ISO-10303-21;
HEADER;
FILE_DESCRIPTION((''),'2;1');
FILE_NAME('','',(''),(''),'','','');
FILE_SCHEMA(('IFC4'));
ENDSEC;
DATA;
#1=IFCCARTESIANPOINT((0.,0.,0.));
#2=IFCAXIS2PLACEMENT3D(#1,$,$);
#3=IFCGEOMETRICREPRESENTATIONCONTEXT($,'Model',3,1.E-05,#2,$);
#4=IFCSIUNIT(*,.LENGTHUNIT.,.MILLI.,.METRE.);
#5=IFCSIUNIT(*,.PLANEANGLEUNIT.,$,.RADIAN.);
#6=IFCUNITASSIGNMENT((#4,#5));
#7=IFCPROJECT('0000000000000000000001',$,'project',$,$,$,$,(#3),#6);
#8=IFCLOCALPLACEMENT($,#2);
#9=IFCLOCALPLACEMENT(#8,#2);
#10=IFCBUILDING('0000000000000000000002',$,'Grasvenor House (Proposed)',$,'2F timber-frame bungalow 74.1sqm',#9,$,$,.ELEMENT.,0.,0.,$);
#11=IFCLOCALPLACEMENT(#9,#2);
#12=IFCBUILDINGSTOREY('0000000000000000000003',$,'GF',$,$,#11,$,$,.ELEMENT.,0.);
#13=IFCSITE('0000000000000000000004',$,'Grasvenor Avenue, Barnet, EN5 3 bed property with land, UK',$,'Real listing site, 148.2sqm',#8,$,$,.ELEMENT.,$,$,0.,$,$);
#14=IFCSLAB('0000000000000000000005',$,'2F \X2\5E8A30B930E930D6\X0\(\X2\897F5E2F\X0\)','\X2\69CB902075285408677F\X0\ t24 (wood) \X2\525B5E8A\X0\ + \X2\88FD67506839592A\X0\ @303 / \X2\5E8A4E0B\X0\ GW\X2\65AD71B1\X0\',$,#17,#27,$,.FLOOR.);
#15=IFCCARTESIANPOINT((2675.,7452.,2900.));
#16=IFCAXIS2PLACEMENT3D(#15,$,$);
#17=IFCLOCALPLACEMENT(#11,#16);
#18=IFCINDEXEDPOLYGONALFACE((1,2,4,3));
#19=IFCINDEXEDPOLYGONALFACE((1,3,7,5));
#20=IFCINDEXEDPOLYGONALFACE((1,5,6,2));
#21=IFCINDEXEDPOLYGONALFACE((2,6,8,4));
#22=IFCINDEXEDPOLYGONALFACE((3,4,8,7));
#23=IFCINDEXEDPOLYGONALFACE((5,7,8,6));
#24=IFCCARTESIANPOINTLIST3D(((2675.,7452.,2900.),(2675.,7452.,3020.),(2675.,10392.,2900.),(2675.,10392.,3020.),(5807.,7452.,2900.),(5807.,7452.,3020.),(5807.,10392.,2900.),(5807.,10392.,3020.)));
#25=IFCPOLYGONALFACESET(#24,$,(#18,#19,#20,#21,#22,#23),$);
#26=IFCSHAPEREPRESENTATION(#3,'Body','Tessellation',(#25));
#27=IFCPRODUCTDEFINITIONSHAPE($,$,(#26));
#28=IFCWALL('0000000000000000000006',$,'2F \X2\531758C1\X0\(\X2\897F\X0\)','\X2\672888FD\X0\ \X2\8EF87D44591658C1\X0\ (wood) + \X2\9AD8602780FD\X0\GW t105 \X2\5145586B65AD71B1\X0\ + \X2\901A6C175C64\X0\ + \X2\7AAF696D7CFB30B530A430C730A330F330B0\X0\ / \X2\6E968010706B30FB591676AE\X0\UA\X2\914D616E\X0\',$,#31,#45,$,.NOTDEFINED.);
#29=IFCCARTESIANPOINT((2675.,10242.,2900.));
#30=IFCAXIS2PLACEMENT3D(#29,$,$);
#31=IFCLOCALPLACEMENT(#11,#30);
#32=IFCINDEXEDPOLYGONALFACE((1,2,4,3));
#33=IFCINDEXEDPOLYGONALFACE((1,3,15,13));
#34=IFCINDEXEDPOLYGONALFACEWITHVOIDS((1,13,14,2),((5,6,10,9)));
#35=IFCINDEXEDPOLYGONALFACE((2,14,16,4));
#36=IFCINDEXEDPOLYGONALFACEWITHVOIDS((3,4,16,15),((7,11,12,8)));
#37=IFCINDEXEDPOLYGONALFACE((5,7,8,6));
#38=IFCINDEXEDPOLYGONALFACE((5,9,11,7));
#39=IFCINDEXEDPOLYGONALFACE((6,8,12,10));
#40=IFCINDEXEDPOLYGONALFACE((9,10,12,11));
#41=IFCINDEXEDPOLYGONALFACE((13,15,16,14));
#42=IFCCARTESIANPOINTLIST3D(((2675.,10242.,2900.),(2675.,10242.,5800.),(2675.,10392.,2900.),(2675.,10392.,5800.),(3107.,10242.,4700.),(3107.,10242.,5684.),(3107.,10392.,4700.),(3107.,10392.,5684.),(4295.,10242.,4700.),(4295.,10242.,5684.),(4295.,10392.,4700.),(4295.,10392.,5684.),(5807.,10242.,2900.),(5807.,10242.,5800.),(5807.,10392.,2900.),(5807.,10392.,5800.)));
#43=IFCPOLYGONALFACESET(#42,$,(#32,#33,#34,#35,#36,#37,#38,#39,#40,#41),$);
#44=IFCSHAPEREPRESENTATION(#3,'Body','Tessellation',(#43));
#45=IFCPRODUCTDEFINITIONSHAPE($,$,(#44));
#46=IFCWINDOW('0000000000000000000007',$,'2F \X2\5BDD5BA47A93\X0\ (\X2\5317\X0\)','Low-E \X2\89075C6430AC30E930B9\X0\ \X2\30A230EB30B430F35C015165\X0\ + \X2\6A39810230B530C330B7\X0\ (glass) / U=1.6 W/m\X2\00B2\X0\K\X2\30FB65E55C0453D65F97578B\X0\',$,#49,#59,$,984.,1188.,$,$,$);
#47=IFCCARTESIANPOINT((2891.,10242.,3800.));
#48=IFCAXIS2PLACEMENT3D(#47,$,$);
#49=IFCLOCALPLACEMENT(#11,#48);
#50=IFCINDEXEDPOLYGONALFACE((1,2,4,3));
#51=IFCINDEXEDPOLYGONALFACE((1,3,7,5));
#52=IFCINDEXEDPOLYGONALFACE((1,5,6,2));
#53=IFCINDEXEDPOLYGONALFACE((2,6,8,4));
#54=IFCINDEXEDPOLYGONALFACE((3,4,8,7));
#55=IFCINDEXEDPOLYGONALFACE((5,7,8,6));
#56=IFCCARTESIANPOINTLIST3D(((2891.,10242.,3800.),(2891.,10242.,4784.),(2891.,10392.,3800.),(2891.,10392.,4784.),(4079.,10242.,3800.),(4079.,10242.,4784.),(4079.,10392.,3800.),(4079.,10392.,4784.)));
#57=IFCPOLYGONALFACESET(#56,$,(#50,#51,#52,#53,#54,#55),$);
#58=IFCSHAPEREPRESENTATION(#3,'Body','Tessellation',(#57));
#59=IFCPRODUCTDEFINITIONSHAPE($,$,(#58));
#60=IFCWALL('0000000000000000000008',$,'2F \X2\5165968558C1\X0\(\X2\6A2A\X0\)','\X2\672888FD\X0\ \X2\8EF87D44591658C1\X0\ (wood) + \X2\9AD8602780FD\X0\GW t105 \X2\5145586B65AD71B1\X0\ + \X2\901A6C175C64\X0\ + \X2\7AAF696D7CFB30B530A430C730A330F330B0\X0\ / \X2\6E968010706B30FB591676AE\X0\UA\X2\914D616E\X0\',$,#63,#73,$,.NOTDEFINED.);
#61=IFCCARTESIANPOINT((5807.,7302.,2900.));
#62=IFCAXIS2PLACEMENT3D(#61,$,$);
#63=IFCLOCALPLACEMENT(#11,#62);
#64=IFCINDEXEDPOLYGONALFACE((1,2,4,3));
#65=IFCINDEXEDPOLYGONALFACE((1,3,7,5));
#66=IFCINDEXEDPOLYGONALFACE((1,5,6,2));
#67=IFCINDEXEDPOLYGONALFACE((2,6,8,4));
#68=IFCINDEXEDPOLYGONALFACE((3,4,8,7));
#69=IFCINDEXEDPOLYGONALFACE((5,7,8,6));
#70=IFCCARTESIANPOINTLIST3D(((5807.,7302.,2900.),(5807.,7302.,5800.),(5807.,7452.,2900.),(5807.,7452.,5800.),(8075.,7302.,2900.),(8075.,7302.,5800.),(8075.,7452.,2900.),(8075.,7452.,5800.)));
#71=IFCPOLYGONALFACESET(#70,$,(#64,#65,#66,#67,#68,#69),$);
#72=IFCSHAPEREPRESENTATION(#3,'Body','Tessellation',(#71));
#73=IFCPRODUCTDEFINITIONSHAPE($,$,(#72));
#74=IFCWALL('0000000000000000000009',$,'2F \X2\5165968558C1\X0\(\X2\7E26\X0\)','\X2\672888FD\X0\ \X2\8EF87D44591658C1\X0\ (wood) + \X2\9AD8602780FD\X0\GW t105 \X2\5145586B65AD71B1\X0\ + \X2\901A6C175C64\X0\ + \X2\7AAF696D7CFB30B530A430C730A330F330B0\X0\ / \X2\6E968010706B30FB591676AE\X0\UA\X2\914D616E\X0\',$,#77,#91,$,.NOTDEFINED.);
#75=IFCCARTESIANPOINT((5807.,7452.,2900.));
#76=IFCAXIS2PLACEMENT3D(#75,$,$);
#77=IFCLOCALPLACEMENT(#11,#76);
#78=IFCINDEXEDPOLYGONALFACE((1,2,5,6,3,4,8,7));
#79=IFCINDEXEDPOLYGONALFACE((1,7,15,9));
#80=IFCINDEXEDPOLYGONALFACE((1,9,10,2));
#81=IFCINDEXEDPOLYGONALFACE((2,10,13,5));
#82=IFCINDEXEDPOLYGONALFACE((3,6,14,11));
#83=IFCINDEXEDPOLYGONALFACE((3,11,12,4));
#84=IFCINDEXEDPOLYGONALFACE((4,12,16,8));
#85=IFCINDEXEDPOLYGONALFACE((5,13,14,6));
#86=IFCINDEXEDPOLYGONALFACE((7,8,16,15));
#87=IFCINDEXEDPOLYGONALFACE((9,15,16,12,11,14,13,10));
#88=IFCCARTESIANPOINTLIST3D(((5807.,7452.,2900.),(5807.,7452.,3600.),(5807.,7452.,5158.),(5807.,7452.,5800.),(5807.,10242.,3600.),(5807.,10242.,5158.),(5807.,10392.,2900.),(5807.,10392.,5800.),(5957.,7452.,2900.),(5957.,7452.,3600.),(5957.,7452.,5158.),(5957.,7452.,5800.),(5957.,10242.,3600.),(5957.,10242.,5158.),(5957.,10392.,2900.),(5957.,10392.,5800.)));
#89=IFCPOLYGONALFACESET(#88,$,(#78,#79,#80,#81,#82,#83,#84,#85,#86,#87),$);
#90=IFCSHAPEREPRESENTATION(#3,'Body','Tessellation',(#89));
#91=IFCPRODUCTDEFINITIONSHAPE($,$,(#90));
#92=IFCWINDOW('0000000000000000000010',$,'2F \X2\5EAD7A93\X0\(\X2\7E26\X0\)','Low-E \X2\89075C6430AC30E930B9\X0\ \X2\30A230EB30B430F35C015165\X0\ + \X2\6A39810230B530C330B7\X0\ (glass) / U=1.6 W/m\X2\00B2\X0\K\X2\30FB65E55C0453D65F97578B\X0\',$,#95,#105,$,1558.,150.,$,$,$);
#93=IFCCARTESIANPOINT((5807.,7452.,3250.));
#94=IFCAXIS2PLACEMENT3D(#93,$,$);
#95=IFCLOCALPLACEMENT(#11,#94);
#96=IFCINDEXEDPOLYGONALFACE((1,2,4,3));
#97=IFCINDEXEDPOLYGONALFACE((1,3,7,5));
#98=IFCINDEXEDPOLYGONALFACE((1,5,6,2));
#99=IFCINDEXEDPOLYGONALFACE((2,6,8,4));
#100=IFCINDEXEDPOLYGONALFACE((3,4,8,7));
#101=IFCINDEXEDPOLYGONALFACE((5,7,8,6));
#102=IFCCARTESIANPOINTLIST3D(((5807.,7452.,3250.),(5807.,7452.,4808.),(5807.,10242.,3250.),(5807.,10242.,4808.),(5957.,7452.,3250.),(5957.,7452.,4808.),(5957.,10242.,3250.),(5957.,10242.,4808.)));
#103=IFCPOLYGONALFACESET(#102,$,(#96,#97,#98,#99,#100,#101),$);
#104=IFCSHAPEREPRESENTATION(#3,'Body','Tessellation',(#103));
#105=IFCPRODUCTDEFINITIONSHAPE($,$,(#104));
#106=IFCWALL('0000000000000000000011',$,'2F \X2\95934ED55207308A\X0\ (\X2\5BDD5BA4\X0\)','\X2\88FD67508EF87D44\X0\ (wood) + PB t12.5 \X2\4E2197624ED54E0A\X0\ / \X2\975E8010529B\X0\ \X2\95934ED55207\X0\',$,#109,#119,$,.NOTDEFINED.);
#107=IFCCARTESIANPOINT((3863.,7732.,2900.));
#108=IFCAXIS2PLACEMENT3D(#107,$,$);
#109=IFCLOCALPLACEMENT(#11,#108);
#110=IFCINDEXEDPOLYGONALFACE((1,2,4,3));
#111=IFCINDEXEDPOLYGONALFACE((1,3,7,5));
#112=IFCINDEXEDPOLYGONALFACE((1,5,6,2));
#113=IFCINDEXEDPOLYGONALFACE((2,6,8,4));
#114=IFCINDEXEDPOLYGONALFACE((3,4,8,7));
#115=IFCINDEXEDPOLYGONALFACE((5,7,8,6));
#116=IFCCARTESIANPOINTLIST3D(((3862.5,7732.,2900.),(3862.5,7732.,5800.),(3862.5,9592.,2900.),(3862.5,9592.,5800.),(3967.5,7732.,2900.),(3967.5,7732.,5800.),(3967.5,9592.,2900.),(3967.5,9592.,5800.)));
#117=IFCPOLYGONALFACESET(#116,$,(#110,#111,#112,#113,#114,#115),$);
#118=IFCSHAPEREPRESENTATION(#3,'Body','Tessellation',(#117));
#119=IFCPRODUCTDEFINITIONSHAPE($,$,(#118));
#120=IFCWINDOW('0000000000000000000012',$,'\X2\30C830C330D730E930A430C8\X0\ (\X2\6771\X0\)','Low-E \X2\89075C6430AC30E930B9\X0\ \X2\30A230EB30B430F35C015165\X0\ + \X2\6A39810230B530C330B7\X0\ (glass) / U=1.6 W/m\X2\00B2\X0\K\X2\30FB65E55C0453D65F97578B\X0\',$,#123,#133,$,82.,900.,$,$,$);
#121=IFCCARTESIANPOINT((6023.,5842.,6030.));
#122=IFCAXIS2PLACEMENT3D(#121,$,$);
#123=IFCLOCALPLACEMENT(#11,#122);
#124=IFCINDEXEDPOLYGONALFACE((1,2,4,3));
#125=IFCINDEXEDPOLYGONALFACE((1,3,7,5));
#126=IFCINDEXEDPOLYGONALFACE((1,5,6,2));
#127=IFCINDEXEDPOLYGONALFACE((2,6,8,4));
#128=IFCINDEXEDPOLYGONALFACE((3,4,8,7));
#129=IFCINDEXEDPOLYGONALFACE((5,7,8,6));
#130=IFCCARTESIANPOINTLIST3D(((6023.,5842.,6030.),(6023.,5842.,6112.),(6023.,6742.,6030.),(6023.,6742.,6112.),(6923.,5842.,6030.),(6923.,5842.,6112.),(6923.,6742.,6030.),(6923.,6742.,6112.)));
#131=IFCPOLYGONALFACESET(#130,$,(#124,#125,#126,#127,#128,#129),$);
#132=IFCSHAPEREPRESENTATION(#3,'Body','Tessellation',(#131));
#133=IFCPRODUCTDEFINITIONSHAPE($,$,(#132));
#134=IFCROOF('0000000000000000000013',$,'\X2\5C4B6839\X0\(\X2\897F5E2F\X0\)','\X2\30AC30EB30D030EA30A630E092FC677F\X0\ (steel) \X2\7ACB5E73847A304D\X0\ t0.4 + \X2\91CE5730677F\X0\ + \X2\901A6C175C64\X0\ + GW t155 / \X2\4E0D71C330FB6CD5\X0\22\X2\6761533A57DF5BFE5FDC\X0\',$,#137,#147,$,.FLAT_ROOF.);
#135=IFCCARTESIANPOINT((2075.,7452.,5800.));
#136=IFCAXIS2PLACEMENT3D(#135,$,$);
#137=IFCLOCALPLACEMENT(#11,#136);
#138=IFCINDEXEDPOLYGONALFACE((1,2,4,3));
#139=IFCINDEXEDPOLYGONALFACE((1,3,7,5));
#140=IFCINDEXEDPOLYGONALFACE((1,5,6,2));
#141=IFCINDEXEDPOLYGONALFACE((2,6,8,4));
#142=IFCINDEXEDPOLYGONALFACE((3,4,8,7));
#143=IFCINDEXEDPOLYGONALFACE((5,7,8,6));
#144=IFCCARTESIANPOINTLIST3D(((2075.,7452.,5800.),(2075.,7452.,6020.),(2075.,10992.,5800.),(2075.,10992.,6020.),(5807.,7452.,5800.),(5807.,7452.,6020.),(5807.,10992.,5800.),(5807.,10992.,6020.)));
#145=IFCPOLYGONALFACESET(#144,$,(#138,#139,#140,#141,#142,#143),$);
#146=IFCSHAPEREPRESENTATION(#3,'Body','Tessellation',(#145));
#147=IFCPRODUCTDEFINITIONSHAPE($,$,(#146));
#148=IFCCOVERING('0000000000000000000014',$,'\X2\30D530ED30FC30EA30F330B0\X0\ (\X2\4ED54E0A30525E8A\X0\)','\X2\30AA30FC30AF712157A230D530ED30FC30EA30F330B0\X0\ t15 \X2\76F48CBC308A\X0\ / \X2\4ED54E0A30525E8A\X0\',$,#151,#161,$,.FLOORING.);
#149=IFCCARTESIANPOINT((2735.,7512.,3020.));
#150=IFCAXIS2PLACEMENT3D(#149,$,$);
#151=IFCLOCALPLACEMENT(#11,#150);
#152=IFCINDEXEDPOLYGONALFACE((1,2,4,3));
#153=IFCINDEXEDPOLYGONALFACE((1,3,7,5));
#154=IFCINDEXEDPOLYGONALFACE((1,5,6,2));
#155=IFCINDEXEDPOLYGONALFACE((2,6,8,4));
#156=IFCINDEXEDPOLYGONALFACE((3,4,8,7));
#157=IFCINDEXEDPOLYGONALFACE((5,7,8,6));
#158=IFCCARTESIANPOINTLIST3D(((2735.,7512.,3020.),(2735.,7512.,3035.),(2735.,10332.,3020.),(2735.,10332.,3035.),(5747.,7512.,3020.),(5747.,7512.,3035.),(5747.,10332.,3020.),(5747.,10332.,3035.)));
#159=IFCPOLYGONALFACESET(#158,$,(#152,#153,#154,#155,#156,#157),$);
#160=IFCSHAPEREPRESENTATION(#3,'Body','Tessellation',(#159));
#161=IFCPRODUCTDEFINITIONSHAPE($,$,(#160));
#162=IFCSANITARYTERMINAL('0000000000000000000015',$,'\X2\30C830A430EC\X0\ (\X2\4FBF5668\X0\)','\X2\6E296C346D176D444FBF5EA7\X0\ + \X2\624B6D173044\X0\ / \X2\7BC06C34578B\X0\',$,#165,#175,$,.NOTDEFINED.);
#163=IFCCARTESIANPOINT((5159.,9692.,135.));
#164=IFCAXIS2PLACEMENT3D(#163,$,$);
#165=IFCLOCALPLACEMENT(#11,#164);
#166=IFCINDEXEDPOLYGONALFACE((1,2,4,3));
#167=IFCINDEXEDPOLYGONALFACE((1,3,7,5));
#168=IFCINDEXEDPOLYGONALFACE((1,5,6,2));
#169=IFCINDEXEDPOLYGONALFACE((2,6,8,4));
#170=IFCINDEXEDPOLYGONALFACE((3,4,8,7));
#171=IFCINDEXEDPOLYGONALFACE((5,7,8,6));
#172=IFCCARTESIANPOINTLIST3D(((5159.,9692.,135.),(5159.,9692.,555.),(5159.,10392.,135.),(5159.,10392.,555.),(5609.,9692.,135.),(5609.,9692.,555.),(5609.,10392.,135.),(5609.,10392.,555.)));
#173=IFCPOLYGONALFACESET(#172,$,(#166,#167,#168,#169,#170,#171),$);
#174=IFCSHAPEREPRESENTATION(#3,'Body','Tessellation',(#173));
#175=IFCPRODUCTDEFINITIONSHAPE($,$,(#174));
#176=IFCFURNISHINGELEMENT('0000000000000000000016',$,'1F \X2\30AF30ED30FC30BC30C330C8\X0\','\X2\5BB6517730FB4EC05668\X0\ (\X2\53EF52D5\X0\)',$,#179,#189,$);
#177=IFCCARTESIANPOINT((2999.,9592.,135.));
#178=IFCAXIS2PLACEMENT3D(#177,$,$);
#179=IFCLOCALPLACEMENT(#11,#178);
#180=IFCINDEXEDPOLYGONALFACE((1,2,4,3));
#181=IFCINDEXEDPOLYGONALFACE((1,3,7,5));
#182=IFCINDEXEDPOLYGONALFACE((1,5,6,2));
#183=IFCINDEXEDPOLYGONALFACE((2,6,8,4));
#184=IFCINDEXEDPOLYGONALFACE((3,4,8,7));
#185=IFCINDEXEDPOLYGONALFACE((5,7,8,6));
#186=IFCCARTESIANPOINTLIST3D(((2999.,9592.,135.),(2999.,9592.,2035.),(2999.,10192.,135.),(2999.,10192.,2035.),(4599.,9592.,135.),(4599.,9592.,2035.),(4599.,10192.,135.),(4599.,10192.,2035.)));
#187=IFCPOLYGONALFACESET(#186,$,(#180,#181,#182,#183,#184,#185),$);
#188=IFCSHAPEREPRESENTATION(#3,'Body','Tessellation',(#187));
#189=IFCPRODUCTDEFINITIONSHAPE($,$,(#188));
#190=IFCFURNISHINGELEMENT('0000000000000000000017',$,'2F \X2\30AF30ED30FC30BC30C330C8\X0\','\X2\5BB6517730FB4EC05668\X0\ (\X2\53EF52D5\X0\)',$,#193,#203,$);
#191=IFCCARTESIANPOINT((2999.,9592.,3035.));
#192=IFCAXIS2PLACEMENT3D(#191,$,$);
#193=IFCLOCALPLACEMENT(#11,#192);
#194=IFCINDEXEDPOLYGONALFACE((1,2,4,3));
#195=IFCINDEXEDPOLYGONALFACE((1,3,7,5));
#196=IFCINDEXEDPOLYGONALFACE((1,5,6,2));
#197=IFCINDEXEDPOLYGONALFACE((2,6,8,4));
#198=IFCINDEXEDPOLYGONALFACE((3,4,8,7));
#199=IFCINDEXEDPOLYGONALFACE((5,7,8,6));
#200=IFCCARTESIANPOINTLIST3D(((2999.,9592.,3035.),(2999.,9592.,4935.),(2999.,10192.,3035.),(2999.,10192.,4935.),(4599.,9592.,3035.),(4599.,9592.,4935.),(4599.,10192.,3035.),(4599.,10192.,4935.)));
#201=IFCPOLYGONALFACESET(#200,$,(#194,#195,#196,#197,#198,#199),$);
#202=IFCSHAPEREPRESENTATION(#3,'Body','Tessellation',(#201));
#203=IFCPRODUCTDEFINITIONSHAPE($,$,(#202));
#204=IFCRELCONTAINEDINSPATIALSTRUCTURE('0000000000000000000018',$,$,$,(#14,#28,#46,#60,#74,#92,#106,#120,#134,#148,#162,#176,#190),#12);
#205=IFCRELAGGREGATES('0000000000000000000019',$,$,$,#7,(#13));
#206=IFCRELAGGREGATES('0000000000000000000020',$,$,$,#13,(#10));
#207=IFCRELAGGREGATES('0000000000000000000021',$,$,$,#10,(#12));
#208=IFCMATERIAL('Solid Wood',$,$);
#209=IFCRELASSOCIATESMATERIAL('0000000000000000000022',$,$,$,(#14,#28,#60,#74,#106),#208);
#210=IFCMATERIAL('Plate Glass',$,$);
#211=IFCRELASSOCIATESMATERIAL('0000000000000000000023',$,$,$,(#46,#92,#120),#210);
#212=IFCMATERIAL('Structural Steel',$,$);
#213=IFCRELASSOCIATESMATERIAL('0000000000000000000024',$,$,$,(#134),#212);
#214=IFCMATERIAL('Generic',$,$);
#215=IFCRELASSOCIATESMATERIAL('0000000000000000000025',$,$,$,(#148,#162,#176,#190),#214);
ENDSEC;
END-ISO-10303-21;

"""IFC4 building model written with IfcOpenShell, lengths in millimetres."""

from ifc_helpers import new_model, si_unit, frame, frame_2d, origin, place, context, project, spatial, rectangle, extrude, material, element, fill, save


model = new_model("IFC4")

# Units and contexts
model_context = context("Model", 3, precision=1e-05, world=origin())
ifc_project = project(units=[si_unit("LENGTHUNIT", "METRE", prefix="MILLI"), si_unit("PLANEANGLEUNIT", "RADIAN")], contexts=[model_context])

# Site, building, storey
site_placement = place(None, origin())
site = spatial("IfcSite", under=ifc_project, at=site_placement, Name="Grasvenor Avenue, Barnet, EN5 3 bed property with land, UK", ObjectType="Real listing site, 148.2sqm", CompositionType="ELEMENT", RefElevation=0.0)
building_placement = place(site_placement, origin())
building = spatial("IfcBuilding", under=site, at=building_placement, Name="Grasvenor House (Proposed)", ObjectType="2F timber-frame bungalow 74.1sqm", CompositionType="ELEMENT", ElevationOfRefHeight=0.0, ElevationOfTerrain=0.0)
storey_placement = place(building_placement, origin())
storey = spatial("IfcBuildingStorey", under=building, at=storey_placement, Name="GF", CompositionType="ELEMENT", Elevation=0.0)

# Slab
ifc_material_1 = material(Name="Solid Wood")
slab_placement = place(storey_placement, frame((2675.0, 7452.0, 2900.0)))
element("IfcSlab", 1, at=slab_placement, inside=storey, material=ifc_material_1, Name="2F 床スラブ(西帯)", Description="構造用合板 t24 (wood) 剛床 + 製材根太 @303 / 床下 GW断熱", PredefinedType="FLOOR", context=model_context, shape_type="SweptSolid", body=[
    extrude(rectangle(XDim=3132.0, YDim=2940.0, at=frame_2d((1566.0, 1470.0))), frame((2675.0, 7452.0, 2900.0)), (0.0, 0.0, 1.0), 120.0),
])

# Wall, opening, window
wall_1_placement = place(storey_placement, frame((2675.0, 10242.0, 2900.0)))
wall_1 = element("IfcWall", 2, at=wall_1_placement, inside=storey, material=ifc_material_1, Name="2F 北壁(西)", Description="木製 軸組外壁 (wood) + 高性能GW t105 充填断熱 + 通気層 + 窯業系サイディング / 準耐火・外皮UA配慮", PredefinedType="NOTDEFINED", context=model_context, shape_type="SweptSolid", body=[
    extrude(rectangle(XDim=3132.0, YDim=150.0, at=frame_2d((1566.0, 75.0))), frame((2675.0, 10242.0, 2900.0)), (0.0, 0.0, 1.0), 2900.0),
])
opening_1_placement = place(storey_placement, frame((2891.0, 10242.0, 3800.0)))
opening_1 = element("IfcOpeningElement", 3, at=opening_1_placement, cuts=wall_1, PredefinedType="NOTDEFINED", context=model_context, shape_type="SweptSolid", body=[
    extrude(rectangle(XDim=1188.0, YDim=150.0, at=frame_2d((594.0, 75.0))), frame((2891.0, 10242.0, 3800.0)), (0.0, 0.0, 1.0), 984.0),
])
ifc_material_2 = material(Name="Plate Glass")
window_1_placement = place(storey_placement, frame((2891.0, 10242.0, 3800.0)))
window_1 = element("IfcWindow", 4, at=window_1_placement, inside=storey, material=ifc_material_2, Name="2F 寝室窓 (北)", Description="Low-E 複層ガラス アルゴン封入 + 樹脂サッシ (glass) / U=1.6 W/m²K・日射取得型", OverallHeight=984.0, OverallWidth=1188.0, context=model_context, shape_type="SweptSolid", body=[
    extrude(rectangle(XDim=1188.0, YDim=150.0, at=frame_2d((594.0, 75.0))), frame((2891.0, 10242.0, 3800.0)), (0.0, 0.0, 1.0), 984.0),
])
fill(opening_1, window_1)

# Wall
wall_2_placement = place(storey_placement, frame((5807.0, 7302.0, 2900.0)))
element("IfcWall", 5, at=wall_2_placement, inside=storey, material=ifc_material_1, Name="2F 入隅壁(横)", Description="木製 軸組外壁 (wood) + 高性能GW t105 充填断熱 + 通気層 + 窯業系サイディング / 準耐火・外皮UA配慮", PredefinedType="NOTDEFINED", context=model_context, shape_type="SweptSolid", body=[
    extrude(rectangle(XDim=2268.0, YDim=150.0, at=frame_2d((1134.0, 75.0))), frame((5807.0, 7302.0, 2900.0)), (0.0, 0.0, 1.0), 2900.0),
])

# Wall, opening, window
wall_3_placement = place(storey_placement, frame((5807.0, 7452.0, 2900.0)))
wall_3 = element("IfcWall", 6, at=wall_3_placement, inside=storey, material=ifc_material_1, Name="2F 入隅壁(縦)", Description="木製 軸組外壁 (wood) + 高性能GW t105 充填断熱 + 通気層 + 窯業系サイディング / 準耐火・外皮UA配慮", PredefinedType="NOTDEFINED", context=model_context, shape_type="SweptSolid", body=[
    extrude(rectangle(XDim=150.0, YDim=2940.0, at=frame_2d((75.0, 1470.0))), frame((5807.0, 7452.0, 2900.0)), (0.0, 0.0, 1.0), 2900.0),
])
opening_2_placement = place(storey_placement, frame((5807.0, 7452.0, 3250.0)))
opening_2 = element("IfcOpeningElement", 7, at=opening_2_placement, cuts=wall_3, PredefinedType="NOTDEFINED", context=model_context, shape_type="SweptSolid", body=[
    extrude(rectangle(XDim=150.0, YDim=2790.0, at=frame_2d((75.0, 1395.0))), frame((5807.0, 7452.0, 3250.0)), (0.0, 0.0, 1.0), 1558.0),
])
window_2_placement = place(storey_placement, frame((5807.0, 7452.0, 3250.0)))
window_2 = element("IfcWindow", 8, at=window_2_placement, inside=storey, material=ifc_material_2, Name="2F 庭窓(縦)", Description="Low-E 複層ガラス アルゴン封入 + 樹脂サッシ (glass) / U=1.6 W/m²K・日射取得型", OverallHeight=1558.0, OverallWidth=150.0, context=model_context, shape_type="SweptSolid", body=[
    extrude(rectangle(XDim=150.0, YDim=2790.0, at=frame_2d((75.0, 1395.0))), frame((5807.0, 7452.0, 3250.0)), (0.0, 0.0, 1.0), 1558.0),
])
fill(opening_2, window_2)

# Wall
wall_4_placement = place(storey_placement, frame((3863.0, 7732.0, 2900.0)))
element("IfcWall", 9, at=wall_4_placement, inside=storey, material=ifc_material_1, Name="2F 間仕切り (寝室)", Description="製材軸組 (wood) + PB t12.5 両面仕上 / 非耐力 間仕切", PredefinedType="NOTDEFINED", context=model_context, shape_type="SweptSolid", body=[
    extrude(rectangle(XDim=105.0, YDim=1860.0, at=frame_2d((52.0, 930.0))), frame((3863.0, 7732.0, 2900.0)), (0.0, 0.0, 1.0), 2900.0),
])

# Window
window_3_placement = place(storey_placement, frame((6023.0, 5842.0, 6030.0)))
element("IfcWindow", 10, at=window_3_placement, inside=storey, material=ifc_material_2, Name="トップライト (東)", Description="Low-E 複層ガラス アルゴン封入 + 樹脂サッシ (glass) / U=1.6 W/m²K・日射取得型", OverallHeight=82.0, OverallWidth=900.0, context=model_context, shape_type="SweptSolid", body=[
    extrude(rectangle(XDim=900.0, YDim=900.0, at=frame_2d((450.0, 450.0))), frame((6023.0, 5842.0, 6030.0)), (0.0, 0.0, 1.0), 82.0),
])

# Roof
ifc_material_3 = material(Name="Structural Steel")
for number, where, name in (
    (11, (2075.0, 7452.0, 5800.0), "屋根(西帯)"),
):
    element("IfcRoof", number, at=place(storey_placement, frame(where)), inside=storey, material=ifc_material_3, Name=name, Description="ガルバリウム鋼板 (steel) 立平葺き t0.4 + 野地板 + 通気層 + GW t155 / 不燃・法22条区域対応", PredefinedType="FLAT_ROOF", context=model_context, shape_type="SweptSolid", body=[
        extrude(rectangle(XDim=3732.0, YDim=3540.0, at=frame_2d((1866.0, 1770.0))), frame((2075.0, 7452.0, 5800.0)), (0.0, 0.0, 1.0), 220.0),
    ])

# Covering
ifc_material_4 = material(Name="Generic")
covering_placement = place(storey_placement, frame((2735.0, 7512.0, 3020.0)))
element("IfcCovering", 12, at=covering_placement, inside=storey, material=ifc_material_4, Name="フローリング (仕上げ床)", Description="オーク無垢フローリング t15 直貼り / 仕上げ床", PredefinedType="FLOORING", context=model_context, shape_type="SweptSolid", body=[
    extrude(rectangle(XDim=3012.0, YDim=2820.0, at=frame_2d((1506.0, 1410.0))), frame((2735.0, 7512.0, 3020.0)), (0.0, 0.0, 1.0), 15.0),
])

# Sanitary terminal
sanitary_terminal_placement = place(storey_placement, frame((5159.0, 9692.0, 135.0)))
element("IfcSanitaryTerminal", 13, at=sanitary_terminal_placement, inside=storey, material=ifc_material_4, Name="トイレ (便器)", Description="温水洗浄便座 + 手洗い / 節水型", PredefinedType="NOTDEFINED", context=model_context, shape_type="SweptSolid", body=[
    extrude(rectangle(XDim=450.0, YDim=700.0, at=frame_2d((225.0, 350.0))), frame((5159.0, 9692.0, 135.0)), (0.0, 0.0, 1.0), 420.0),
])

# Furnishing elements
furnishing_1_placement = place(storey_placement, frame((2999.0, 9592.0, 135.0)))
element("IfcFurnishingElement", 14, at=furnishing_1_placement, inside=storey, material=ifc_material_4, Name="1F クローゼット", Description="家具・什器 (可動)", context=model_context, shape_type="SweptSolid", body=[
    extrude(rectangle(XDim=1600.0, YDim=600.0, at=frame_2d((800.0, 300.0))), frame((2999.0, 9592.0, 135.0)), (0.0, 0.0, 1.0), 1900.0),
])
furnishing_2_placement = place(storey_placement, frame((2999.0, 9592.0, 3035.0)))
element("IfcFurnishingElement", 15, at=furnishing_2_placement, inside=storey, material=ifc_material_4, Name="2F クローゼット", Description="家具・什器 (可動)", context=model_context, shape_type="SweptSolid", body=[
    extrude(rectangle(XDim=1600.0, YDim=600.0, at=frame_2d((800.0, 300.0))), frame((2999.0, 9592.0, 3035.0)), (0.0, 0.0, 1.0), 1900.0),
])

save(model, "model.ifc")
